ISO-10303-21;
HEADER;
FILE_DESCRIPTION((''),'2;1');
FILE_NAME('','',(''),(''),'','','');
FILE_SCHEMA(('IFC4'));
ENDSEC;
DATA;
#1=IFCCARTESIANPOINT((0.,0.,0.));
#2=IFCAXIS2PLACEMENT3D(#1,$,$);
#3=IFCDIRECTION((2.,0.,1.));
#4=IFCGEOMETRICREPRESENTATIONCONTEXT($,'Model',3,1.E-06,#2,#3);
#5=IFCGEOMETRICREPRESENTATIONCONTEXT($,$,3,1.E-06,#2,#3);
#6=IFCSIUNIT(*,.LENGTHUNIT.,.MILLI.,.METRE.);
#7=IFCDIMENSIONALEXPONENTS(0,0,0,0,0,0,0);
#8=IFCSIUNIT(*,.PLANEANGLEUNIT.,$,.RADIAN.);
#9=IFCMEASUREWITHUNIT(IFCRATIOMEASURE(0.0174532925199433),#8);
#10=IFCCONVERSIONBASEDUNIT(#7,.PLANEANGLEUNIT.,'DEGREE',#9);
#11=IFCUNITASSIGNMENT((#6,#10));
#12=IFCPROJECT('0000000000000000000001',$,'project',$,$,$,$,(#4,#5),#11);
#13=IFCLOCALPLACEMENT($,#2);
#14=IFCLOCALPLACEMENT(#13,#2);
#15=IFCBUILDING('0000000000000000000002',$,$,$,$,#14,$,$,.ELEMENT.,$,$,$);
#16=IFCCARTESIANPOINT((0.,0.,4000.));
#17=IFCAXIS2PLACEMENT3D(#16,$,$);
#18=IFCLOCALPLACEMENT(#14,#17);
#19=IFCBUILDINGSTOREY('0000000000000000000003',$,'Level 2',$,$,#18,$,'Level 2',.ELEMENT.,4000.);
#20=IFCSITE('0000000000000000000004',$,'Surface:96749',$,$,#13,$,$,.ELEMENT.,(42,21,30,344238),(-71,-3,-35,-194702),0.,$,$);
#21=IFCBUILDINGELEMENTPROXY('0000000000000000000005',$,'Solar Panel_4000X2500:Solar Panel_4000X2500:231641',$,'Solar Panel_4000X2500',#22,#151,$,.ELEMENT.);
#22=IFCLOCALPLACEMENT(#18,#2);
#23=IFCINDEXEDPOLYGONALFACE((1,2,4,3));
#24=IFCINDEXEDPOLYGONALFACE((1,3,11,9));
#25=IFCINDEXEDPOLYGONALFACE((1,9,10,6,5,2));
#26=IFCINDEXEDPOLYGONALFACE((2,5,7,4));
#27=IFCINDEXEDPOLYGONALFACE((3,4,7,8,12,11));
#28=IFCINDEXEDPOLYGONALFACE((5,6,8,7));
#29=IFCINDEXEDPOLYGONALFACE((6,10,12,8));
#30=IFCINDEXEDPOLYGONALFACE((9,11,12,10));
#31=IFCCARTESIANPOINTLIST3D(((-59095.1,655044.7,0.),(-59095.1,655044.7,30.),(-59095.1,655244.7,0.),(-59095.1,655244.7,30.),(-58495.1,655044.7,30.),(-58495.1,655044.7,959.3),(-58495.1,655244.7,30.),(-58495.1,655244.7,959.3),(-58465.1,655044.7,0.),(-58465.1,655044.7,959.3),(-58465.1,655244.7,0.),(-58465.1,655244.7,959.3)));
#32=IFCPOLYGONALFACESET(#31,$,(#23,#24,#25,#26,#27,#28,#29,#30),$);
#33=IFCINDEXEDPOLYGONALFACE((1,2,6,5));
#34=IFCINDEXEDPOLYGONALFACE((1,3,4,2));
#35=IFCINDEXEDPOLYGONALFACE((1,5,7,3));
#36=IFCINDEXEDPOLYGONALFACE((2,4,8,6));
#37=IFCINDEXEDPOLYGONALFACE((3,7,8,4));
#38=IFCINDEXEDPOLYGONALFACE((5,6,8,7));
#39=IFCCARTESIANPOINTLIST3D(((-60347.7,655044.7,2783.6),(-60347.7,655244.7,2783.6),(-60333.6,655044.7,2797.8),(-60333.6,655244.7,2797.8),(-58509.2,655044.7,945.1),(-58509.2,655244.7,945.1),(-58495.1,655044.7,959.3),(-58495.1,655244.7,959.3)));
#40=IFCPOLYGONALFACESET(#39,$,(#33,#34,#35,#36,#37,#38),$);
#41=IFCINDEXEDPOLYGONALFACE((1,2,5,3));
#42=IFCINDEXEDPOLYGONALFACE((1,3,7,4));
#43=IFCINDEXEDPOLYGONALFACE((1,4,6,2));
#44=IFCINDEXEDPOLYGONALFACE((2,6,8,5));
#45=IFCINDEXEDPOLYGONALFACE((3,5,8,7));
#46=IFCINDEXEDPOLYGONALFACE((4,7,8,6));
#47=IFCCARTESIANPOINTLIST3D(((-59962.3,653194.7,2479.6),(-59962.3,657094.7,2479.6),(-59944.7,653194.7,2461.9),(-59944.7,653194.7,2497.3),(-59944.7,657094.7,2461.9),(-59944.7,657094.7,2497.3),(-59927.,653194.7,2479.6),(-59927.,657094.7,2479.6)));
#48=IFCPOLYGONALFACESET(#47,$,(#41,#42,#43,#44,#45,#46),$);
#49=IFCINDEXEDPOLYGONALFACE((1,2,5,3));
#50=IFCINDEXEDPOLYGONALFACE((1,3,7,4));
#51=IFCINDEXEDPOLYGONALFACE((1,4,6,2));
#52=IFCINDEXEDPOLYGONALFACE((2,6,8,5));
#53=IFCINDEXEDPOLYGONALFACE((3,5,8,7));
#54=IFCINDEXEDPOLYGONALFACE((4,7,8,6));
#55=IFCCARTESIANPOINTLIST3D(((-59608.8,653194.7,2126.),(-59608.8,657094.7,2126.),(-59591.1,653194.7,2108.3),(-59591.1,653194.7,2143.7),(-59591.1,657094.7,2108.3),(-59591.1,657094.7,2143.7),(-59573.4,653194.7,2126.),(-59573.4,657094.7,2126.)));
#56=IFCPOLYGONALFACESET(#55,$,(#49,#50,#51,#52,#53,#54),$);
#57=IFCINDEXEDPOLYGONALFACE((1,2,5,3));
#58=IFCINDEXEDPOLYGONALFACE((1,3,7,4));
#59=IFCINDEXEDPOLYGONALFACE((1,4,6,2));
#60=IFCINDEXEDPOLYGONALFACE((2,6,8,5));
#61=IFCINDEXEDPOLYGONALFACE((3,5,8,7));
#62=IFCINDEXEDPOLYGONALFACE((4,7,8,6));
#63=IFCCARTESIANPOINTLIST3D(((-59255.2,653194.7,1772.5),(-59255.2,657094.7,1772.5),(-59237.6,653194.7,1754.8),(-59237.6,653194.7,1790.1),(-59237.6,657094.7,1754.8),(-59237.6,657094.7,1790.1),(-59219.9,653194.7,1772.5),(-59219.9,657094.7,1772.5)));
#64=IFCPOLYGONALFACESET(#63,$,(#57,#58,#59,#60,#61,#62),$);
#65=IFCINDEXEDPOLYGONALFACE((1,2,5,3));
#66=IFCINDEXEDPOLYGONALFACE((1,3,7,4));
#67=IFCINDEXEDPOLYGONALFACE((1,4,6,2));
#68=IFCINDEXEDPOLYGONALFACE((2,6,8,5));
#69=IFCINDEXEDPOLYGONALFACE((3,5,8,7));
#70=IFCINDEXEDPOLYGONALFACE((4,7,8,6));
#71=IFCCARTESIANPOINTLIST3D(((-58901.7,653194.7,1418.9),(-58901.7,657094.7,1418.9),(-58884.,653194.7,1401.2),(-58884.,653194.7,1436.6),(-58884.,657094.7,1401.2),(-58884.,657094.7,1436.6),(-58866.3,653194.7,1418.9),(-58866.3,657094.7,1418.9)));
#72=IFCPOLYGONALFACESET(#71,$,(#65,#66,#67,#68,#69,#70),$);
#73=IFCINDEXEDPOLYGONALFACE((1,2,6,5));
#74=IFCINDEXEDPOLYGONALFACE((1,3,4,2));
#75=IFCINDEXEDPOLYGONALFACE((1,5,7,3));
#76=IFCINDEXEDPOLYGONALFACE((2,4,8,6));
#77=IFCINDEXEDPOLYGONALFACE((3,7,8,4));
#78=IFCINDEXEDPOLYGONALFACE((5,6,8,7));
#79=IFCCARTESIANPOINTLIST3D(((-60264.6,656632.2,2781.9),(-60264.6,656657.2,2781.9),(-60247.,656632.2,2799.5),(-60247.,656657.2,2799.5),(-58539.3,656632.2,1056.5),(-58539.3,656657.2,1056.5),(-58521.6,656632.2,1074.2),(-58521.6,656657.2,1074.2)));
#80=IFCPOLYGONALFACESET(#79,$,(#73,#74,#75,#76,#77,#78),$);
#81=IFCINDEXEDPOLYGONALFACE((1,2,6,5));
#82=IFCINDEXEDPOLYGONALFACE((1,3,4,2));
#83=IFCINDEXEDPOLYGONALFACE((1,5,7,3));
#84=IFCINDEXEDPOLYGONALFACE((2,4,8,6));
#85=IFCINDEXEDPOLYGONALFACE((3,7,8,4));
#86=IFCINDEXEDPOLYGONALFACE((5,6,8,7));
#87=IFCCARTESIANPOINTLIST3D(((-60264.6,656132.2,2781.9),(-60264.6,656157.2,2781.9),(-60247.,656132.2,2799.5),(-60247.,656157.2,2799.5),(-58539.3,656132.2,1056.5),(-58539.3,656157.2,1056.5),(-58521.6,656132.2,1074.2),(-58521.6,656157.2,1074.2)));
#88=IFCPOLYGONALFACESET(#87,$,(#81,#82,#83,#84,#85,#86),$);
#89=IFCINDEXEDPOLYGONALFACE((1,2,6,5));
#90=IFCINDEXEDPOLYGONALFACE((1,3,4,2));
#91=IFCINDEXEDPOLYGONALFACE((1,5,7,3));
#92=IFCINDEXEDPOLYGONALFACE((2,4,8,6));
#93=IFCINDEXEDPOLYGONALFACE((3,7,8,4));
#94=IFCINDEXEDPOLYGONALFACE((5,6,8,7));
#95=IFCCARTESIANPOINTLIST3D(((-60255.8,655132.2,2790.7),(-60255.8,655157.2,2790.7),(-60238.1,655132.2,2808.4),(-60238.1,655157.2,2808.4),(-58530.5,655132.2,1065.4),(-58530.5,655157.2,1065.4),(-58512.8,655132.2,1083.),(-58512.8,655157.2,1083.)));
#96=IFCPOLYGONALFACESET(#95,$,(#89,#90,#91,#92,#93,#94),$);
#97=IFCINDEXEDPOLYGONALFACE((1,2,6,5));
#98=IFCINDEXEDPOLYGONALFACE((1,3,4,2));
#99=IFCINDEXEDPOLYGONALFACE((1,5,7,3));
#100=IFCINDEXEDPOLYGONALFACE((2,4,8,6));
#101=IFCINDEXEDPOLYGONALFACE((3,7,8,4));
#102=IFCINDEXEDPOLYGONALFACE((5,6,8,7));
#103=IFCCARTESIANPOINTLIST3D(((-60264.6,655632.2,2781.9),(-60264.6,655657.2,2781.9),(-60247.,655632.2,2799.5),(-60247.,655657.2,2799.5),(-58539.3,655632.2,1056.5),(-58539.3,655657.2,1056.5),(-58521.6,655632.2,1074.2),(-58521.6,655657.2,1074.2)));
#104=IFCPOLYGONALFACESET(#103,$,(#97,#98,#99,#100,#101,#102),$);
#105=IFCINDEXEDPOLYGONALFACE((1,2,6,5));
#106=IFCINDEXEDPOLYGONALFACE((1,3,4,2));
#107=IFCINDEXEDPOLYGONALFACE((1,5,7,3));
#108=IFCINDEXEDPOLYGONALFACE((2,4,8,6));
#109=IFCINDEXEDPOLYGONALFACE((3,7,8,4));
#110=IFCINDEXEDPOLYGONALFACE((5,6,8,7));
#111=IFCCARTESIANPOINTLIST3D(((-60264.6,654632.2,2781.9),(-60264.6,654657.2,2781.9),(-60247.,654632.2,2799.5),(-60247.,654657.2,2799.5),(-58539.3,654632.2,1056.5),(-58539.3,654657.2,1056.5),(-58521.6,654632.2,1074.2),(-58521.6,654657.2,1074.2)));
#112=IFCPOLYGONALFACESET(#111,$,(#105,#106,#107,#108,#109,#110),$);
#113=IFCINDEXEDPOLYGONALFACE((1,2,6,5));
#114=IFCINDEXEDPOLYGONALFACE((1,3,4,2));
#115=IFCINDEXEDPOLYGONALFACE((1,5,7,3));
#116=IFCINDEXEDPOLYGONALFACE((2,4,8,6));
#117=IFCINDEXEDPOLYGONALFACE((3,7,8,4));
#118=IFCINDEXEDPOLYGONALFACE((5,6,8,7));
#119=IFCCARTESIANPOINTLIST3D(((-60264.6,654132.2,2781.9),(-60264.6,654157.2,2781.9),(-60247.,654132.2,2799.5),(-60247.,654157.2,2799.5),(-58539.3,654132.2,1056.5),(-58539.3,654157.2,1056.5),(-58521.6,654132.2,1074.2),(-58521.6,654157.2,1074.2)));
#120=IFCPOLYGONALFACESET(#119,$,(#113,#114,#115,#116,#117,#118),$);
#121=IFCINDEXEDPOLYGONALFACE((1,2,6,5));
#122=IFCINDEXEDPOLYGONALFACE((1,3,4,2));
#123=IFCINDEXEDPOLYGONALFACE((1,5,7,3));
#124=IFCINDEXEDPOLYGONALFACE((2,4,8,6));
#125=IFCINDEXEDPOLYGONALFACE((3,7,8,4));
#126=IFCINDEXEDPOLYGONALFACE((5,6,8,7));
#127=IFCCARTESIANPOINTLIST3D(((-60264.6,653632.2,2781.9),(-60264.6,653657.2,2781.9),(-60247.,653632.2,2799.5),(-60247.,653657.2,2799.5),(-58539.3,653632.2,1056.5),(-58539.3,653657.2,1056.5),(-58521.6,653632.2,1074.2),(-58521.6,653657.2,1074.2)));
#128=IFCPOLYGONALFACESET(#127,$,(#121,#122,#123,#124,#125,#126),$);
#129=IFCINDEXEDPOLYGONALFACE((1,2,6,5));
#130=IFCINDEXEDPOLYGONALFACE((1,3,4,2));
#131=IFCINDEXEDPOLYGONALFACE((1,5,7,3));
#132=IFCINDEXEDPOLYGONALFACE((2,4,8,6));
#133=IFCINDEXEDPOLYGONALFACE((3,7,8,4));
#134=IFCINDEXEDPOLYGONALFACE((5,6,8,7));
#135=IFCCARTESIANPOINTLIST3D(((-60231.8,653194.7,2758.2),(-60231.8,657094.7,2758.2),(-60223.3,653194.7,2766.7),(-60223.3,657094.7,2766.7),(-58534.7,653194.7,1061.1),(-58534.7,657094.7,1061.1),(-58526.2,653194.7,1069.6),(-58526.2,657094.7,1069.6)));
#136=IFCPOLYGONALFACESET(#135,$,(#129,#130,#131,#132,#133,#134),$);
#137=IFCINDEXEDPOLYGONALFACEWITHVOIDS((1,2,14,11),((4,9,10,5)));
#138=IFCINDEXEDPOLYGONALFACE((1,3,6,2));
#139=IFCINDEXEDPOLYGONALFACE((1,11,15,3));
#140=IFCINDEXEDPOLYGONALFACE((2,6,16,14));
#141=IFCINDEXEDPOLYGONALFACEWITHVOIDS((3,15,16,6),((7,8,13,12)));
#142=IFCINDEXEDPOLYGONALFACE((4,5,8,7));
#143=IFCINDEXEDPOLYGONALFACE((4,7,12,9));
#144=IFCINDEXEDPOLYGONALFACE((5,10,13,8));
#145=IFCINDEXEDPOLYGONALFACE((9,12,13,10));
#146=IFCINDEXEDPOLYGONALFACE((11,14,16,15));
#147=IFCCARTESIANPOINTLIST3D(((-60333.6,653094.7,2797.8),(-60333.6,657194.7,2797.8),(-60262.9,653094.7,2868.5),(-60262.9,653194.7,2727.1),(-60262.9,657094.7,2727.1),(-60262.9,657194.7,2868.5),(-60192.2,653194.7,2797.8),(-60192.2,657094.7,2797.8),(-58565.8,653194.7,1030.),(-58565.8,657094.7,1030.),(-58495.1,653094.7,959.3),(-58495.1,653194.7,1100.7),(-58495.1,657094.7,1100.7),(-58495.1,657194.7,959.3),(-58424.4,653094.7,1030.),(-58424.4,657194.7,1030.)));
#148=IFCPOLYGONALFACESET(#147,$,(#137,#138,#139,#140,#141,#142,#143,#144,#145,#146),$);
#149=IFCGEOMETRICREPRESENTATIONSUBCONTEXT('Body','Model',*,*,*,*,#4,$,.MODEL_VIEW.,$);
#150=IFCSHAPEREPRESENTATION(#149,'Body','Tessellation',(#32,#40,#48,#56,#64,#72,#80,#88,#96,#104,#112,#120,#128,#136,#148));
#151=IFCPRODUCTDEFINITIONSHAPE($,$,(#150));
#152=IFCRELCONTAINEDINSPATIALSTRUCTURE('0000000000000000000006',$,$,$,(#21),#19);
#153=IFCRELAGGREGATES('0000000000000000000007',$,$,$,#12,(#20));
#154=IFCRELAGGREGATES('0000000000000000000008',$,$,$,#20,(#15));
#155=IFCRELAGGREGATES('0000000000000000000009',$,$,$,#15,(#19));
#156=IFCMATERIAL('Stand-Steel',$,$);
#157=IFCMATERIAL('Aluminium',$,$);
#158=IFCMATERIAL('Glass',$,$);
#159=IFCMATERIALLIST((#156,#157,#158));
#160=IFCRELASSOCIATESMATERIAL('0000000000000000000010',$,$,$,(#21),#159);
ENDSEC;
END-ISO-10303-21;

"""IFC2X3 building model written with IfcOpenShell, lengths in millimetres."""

from ifc_helpers import new_model, entity, si_unit, converted_unit, direction, frame, frame_2d, origin, origin_2d_with_axis, place, context, subcontext, project, spatial, polyline, rectangle, outline, extrude, source, transform, mapped, material, material_list, element, save


model = new_model("IFC2X3")

# Units and contexts
model_context = context("Model", 3, precision=1e-06, world=origin(), true_north=direction((2.0, 0.0, 1.0)))
context_of_model = context(None, 3, precision=1e-06, world=origin(), true_north=direction((2.0, 0.0, 1.0)))
body_context = subcontext(model_context, "Body", "Model", "MODEL_VIEW")
ifc_project = project(units=[si_unit("LENGTHUNIT", "METRE", prefix="MILLI"), converted_unit("PLANEANGLEUNIT", "DEGREE", entity("IfcRatioMeasure", 0.0174532925199433), si_unit("PLANEANGLEUNIT", "RADIAN"), dimensions=[0, 0, 0, 0, 0, 0, 0])], contexts=[model_context, context_of_model])

# Site, building, storey
site_placement = place(None, origin())
site = spatial("IfcSite", under=ifc_project, at=site_placement, Name="Surface:96749", CompositionType="ELEMENT", RefLatitude=(42, 21, 30, 344238), RefLongitude=(-71, -3, -35, -194702), RefElevation=0.0)
building_placement = place(site_placement, origin())
building = spatial("IfcBuilding", under=site, at=building_placement, CompositionType="ELEMENT")
storey_placement = place(building_placement, frame((0.0, 0.0, 4000.0)))
storey = spatial("IfcBuildingStorey", under=building, at=storey_placement, Name="Level 2", LongName="Level 2", CompositionType="ELEMENT", Elevation=4000.0)

# Building element proxy
ifc_material_1 = material(Name="Stand-Steel")
ifc_material_2 = material(Name="Aluminium")
ifc_material_3 = material(Name="Glass")
shared_shape = source(origin(), body_context, "Body", "SweptSolid", [
    extrude(outline(polyline([(-629.5, -220.0), (329.8, -220.0), (329.8, 410.0), (299.8, 410.0), (299.8, -190.0), (-629.5, -190.0), (-629.5, -220.0)])), frame((-190.0, -100.0, 299.8), z_axis=(0.0, 1.0, 0.0), x_axis=(0.0, 0.0, -1.0)), (0.0, 0.0, 1.0), 200.0),
    extrude(rectangle(XDim=20.0, YDim=200.0, at=frame_2d((0.0, 0.0), x_axis=(0.0, 1.0))), frame((-7.1, 0.0, 922.2), z_axis=(-0.707107, 0.0, 0.707107), x_axis=(0.0, 1.0, 0.0)), (0.0, 0.0, 1.0), 2600.0),
    extrude(rectangle(XDim=25.0, YDim=25.0, at=frame_2d((0.0, 0.0), x_axis=(1.0, 0.0))), frame((-1449.6, -1950.0, 2449.6), z_axis=(0.0, 1.0, 0.0), x_axis=(-0.707107, 0.0, -0.707107)), (0.0, 0.0, 1.0), 3900.0),
    extrude(rectangle(XDim=25.0, YDim=25.0, at=origin_2d_with_axis()), frame((-1096.0, -1950.0, 2096.0), z_axis=(0.0, 1.0, 0.0), x_axis=(-0.707107, 0.0, -0.707107)), (0.0, 0.0, 1.0), 3900.0),
    extrude(rectangle(XDim=25.0, YDim=25.0, at=origin_2d_with_axis()), frame((-742.5, -1950.0, 1742.5), z_axis=(0.0, 1.0, 0.0), x_axis=(-0.707107, 0.0, -0.707107)), (0.0, 0.0, 1.0), 3900.0),
    extrude(rectangle(XDim=25.0, YDim=25.0, at=frame_2d((0.0, 0.0), x_axis=(1.0, 0.0))), frame((-388.9, -1950.0, 1388.9), z_axis=(0.0, 1.0, 0.0), x_axis=(-0.707107, 0.0, -0.707107)), (0.0, 0.0, 1.0), 3900.0),
    extrude(rectangle(XDim=25.0, YDim=25.0, at=frame_2d((0.0, 0.0), x_axis=(0.0, 1.0))), frame((-35.4, 1500.0, 1035.4), z_axis=(-0.707107, 0.0, 0.707107), x_axis=(0.0, 1.0, 0.0)), (0.0, 0.0, 1.0), 2440.0),
    extrude(rectangle(XDim=25.0, YDim=25.0, at=frame_2d((0.0, 0.0), x_axis=(0.0, 1.0))), frame((-35.4, 1000.0, 1035.4), z_axis=(-0.707107, 0.0, 0.707107), x_axis=(0.0, 1.0, 0.0)), (0.0, 0.0, 1.0), 2440.0),
    extrude(rectangle(XDim=25.0, YDim=25.0, at=frame_2d((0.0, 0.0), x_axis=(0.0, 1.0))), frame((-26.5, 0.0, 1044.2), z_axis=(-0.707107, 0.0, 0.707107), x_axis=(0.0, -1.0, 0.0)), (0.0, 0.0, 1.0), 2440.0),
    extrude(rectangle(XDim=25.0, YDim=25.0, at=frame_2d((0.0, 0.0), x_axis=(0.0, 1.0))), frame((-35.4, 500.0, 1035.4), z_axis=(-0.707107, 0.0, 0.707107), x_axis=(0.0, 1.0, 0.0)), (0.0, 0.0, 1.0), 2440.0),
    extrude(rectangle(XDim=25.0, YDim=25.0, at=frame_2d((0.0, 0.0), x_axis=(0.0, 1.0))), frame((-35.4, -500.0, 1035.4), z_axis=(-0.707107, 0.0, 0.707107), x_axis=(0.0, 1.0, 0.0)), (0.0, 0.0, 1.0), 2440.0),
    extrude(rectangle(XDim=25.0, YDim=25.0, at=frame_2d((0.0, 0.0), x_axis=(0.0, 1.0))), frame((-35.4, -1000.0, 1035.4), z_axis=(-0.707107, 0.0, 0.707107), x_axis=(0.0, 1.0, 0.0)), (0.0, 0.0, 1.0), 2440.0),
    extrude(rectangle(XDim=25.0, YDim=25.0, at=frame_2d((0.0, 0.0), x_axis=(0.0, 1.0))), frame((-35.4, -1500.0, 1035.4), z_axis=(-0.707107, 0.0, 0.707107), x_axis=(0.0, 1.0, 0.0)), (0.0, 0.0, 1.0), 2440.0),
    extrude(rectangle(XDim=2400.0, YDim=12.0, at=frame_2d((0.0, 0.0), x_axis=(1.0, 0.0))), frame((-883.9, -1950.0, 1883.9), z_axis=(0.0, 1.0, 0.0), x_axis=(0.707107, 0.0, -0.707107)), (0.0, 0.0, 1.0), 3900.0),
    extrude(outline(polyline([(-2050.0, -1300.0), (2050.0, -1300.0), (2050.0, 1300.0), (-2050.0, 1300.0), (-2050.0, -1300.0)]), holes=[polyline([(1950.0, -1200.0), (-1950.0, -1200.0), (-1950.0, 1200.0), (1950.0, 1200.0), (1950.0, -1200.0)])]), frame((-919.2, 0.0, 1848.5), z_axis=(0.707107, 0.0, 0.707107), x_axis=(0.0, 1.0, 0.0)), (0.0, 0.0, 1.0), 100.0),
])
ifc_material_list_1 = material_list([ifc_material_1, ifc_material_2, ifc_material_3])
proxy_1_placement = place(storey_placement, frame((-58495.1, 655144.7, 30.0)))
element("IfcBuildingElementProxy", 1, at=proxy_1_placement, inside=storey, material=ifc_material_list_1, Name="Solar Panel_4000X2500:Solar Panel_4000X2500:231641", ObjectType="Solar Panel_4000X2500", CompositionType="ELEMENT", context=body_context, shape_type="MappedRepresentation", body=[
    mapped(shared_shape, transform((0.0, 0.0, 0.0), scale=1.0)),
])

save(model, "model.ifc")
